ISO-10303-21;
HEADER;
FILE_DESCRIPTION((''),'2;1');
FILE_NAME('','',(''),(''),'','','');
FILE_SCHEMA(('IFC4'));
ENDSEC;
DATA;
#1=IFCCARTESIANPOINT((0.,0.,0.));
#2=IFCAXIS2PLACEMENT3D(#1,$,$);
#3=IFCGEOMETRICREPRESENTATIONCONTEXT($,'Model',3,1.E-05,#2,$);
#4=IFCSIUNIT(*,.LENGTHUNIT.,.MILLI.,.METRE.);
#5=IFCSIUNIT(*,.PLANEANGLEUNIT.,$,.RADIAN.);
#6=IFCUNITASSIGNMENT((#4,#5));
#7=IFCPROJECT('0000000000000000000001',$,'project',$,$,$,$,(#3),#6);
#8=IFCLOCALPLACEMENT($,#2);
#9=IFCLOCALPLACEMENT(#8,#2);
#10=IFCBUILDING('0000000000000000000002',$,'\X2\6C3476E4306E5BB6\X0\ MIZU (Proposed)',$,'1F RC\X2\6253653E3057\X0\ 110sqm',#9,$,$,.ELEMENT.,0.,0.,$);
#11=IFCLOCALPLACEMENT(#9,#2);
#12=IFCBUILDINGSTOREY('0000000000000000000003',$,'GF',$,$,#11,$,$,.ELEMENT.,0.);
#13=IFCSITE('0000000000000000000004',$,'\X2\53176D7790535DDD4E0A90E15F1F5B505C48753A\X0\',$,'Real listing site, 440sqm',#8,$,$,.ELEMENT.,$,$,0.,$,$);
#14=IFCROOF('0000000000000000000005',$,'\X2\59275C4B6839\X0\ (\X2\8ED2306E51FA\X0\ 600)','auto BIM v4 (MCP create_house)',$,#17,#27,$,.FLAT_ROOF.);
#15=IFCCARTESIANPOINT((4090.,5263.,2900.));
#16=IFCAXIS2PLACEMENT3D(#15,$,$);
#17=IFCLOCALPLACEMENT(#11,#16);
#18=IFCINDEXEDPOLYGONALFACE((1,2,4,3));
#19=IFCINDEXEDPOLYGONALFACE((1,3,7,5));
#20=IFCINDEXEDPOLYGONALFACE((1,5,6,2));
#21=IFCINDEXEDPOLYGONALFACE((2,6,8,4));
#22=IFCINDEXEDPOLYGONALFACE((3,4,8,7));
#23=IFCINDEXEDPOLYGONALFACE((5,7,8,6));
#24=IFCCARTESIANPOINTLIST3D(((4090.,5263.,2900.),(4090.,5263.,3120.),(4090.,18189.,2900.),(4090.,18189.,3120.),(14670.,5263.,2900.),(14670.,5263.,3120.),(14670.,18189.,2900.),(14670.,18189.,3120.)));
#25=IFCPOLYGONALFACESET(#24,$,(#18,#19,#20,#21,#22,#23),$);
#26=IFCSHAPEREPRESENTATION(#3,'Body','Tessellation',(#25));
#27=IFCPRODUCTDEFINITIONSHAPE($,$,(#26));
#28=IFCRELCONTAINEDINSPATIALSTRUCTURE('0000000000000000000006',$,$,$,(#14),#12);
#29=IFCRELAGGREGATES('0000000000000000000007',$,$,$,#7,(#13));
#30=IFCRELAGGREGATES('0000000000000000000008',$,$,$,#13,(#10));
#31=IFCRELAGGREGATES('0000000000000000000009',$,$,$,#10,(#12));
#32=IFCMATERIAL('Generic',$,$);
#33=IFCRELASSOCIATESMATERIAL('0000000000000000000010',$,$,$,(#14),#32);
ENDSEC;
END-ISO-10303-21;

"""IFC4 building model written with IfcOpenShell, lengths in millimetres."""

from ifc_helpers import new_model, si_unit, frame, frame_2d, origin, place, context, project, spatial, rectangle, extrude, material, element, save


model = new_model("IFC4")

# Units and contexts
model_context = context("Model", 3, precision=1e-05, world=origin())
ifc_project = project(units=[si_unit("LENGTHUNIT", "METRE", prefix="MILLI"), si_unit("PLANEANGLEUNIT", "RADIAN")], contexts=[model_context])

# Site, building, storey
site_placement = place(None, origin())
site = spatial("IfcSite", under=ifc_project, at=site_placement, Name="北海道川上郡弟子屈町", ObjectType="Real listing site, 440sqm", CompositionType="ELEMENT", RefElevation=0.0)
building_placement = place(site_placement, origin())
building = spatial("IfcBuilding", under=site, at=building_placement, Name="水盤の家 MIZU (Proposed)", ObjectType="1F RC打放し 110sqm", CompositionType="ELEMENT", ElevationOfRefHeight=0.0, ElevationOfTerrain=0.0)
storey_placement = place(building_placement, origin())
storey = spatial("IfcBuildingStorey", under=building, at=storey_placement, Name="GF", CompositionType="ELEMENT", Elevation=0.0)

# Shared definitions
ifc_material = material(Name="Generic")

# Roof
roof_placement = place(storey_placement, frame((4090.0, 5263.0, 2900.0)))
element("IfcRoof", 1, at=roof_placement, inside=storey, material=ifc_material, Name="大屋根 (軒の出 600)", Description="auto BIM v4 (MCP create_house)", PredefinedType="FLAT_ROOF", context=model_context, shape_type="SweptSolid", body=[
    extrude(rectangle(XDim=10580.0, YDim=12926.0, at=frame_2d((5290.0, 6463.0))), frame((4090.0, 5263.0, 2900.0)), (0.0, 0.0, 1.0), 220.0),
])

save(model, "model.ifc")
